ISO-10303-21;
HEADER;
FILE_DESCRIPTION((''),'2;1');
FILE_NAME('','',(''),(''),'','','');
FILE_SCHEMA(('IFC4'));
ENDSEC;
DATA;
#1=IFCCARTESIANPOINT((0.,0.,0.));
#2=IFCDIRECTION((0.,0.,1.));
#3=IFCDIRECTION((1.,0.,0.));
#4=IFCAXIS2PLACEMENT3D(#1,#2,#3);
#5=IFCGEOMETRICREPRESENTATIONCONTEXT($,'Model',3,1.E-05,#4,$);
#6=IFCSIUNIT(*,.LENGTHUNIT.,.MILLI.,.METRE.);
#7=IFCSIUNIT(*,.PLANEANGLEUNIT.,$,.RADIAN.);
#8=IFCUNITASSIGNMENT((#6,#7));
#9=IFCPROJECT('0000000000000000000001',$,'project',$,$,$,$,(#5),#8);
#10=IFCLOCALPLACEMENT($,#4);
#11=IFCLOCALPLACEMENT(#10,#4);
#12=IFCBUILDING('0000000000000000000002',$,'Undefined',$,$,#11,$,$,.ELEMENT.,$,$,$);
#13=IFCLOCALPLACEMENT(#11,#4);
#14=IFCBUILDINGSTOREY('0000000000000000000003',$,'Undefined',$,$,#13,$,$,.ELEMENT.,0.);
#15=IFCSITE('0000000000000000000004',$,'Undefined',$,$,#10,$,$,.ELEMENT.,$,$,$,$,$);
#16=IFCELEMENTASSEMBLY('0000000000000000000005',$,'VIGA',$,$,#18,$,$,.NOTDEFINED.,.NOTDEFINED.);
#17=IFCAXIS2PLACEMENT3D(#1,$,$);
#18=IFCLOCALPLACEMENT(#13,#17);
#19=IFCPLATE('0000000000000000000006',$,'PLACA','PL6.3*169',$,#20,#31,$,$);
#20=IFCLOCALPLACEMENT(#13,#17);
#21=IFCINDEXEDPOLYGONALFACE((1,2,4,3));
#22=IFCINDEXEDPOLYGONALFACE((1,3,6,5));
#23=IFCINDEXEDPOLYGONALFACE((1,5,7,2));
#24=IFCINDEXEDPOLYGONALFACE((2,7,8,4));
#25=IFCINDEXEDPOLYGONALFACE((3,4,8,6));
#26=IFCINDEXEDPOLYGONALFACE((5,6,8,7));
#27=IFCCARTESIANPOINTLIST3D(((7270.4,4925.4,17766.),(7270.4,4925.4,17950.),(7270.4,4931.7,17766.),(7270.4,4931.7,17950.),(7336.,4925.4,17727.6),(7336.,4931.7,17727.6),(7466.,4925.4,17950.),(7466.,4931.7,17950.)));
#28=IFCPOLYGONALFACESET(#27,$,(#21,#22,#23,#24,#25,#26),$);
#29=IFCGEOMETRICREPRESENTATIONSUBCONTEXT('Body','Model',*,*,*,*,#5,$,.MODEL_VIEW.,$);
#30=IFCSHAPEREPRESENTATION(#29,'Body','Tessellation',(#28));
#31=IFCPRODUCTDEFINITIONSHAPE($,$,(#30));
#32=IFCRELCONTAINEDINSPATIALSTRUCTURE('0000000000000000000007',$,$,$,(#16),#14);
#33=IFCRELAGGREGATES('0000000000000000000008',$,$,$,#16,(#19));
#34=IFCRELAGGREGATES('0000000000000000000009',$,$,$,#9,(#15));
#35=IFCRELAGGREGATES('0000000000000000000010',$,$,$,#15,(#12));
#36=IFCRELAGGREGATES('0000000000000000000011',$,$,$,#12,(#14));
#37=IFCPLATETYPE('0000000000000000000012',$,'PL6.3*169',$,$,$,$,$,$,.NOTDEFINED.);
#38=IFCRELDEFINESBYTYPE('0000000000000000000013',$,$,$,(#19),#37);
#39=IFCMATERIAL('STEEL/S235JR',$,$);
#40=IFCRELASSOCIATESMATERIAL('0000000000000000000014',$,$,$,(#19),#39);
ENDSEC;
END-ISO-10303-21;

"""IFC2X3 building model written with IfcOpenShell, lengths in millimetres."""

from ifc_helpers import new_model, si_unit, frame, origin_with_axes, place, context, subcontext, project, spatial, polyline, outline, extrude, material, type_object, element, aggregate, save


model = new_model("IFC2X3")

# Units and contexts
model_context = context("Model", 3, precision=1e-05, world=origin_with_axes())
body_context = subcontext(model_context, "Body", "Model", "MODEL_VIEW")
ifc_project = project(units=[si_unit("LENGTHUNIT", "METRE", prefix="MILLI"), si_unit("PLANEANGLEUNIT", "RADIAN")], contexts=[model_context])

# Site, building, storey
site_placement = place(None, origin_with_axes())
site = spatial("IfcSite", under=ifc_project, at=site_placement, Name="Undefined", CompositionType="ELEMENT")
building_placement = place(site_placement, origin_with_axes())
building = spatial("IfcBuilding", under=site, at=building_placement, Name="Undefined", CompositionType="ELEMENT")
storey_placement = place(building_placement, origin_with_axes())
storey = spatial("IfcBuildingStorey", under=building, at=storey_placement, Name="Undefined", CompositionType="ELEMENT", Elevation=0.0)

# Shared definitions
ifc_material_1 = material(Name="STEEL/S235JR")

# Element assembly, plate
assembly_1_placement = place(storey_placement, origin_with_axes())
assembly_1 = element("IfcElementAssembly", 1, at=assembly_1_placement, inside=storey, Name="VIGA", AssemblyPlace="NOTDEFINED", PredefinedType="NOTDEFINED")
plate_type_1 = type_object("IfcPlateType", Name="PL6.3*169", PredefinedType="NOTDEFINED")
plate_1_placement = place(assembly_1_placement, frame((7466.0, 4928.6, 17950.0), z_axis=(0.0, -1.0, 0.0), x_axis=(-1.0, 0.0, 0.0)))
plate_1 = element("IfcPlate", 2, at=plate_1_placement, type_object=plate_type_1, material=ifc_material_1, Name="PLACA", Description="PL6.3*169", context=body_context, shape_type="SweptSolid", body=[
    extrude(outline(polyline([(0.0, 0.0), (195.6, 0.0), (195.6, 184.0), (130.0, 222.4), (0.0, 0.0)])), frame((0.0, 0.0, -3.1), z_axis=(0.0, 0.0, 1.0), x_axis=(1.0, 0.0, 0.0)), (0.0, 0.0, 1.0), 6.3),
])
aggregate(assembly_1, [plate_1])

save(model, "model.ifc")
